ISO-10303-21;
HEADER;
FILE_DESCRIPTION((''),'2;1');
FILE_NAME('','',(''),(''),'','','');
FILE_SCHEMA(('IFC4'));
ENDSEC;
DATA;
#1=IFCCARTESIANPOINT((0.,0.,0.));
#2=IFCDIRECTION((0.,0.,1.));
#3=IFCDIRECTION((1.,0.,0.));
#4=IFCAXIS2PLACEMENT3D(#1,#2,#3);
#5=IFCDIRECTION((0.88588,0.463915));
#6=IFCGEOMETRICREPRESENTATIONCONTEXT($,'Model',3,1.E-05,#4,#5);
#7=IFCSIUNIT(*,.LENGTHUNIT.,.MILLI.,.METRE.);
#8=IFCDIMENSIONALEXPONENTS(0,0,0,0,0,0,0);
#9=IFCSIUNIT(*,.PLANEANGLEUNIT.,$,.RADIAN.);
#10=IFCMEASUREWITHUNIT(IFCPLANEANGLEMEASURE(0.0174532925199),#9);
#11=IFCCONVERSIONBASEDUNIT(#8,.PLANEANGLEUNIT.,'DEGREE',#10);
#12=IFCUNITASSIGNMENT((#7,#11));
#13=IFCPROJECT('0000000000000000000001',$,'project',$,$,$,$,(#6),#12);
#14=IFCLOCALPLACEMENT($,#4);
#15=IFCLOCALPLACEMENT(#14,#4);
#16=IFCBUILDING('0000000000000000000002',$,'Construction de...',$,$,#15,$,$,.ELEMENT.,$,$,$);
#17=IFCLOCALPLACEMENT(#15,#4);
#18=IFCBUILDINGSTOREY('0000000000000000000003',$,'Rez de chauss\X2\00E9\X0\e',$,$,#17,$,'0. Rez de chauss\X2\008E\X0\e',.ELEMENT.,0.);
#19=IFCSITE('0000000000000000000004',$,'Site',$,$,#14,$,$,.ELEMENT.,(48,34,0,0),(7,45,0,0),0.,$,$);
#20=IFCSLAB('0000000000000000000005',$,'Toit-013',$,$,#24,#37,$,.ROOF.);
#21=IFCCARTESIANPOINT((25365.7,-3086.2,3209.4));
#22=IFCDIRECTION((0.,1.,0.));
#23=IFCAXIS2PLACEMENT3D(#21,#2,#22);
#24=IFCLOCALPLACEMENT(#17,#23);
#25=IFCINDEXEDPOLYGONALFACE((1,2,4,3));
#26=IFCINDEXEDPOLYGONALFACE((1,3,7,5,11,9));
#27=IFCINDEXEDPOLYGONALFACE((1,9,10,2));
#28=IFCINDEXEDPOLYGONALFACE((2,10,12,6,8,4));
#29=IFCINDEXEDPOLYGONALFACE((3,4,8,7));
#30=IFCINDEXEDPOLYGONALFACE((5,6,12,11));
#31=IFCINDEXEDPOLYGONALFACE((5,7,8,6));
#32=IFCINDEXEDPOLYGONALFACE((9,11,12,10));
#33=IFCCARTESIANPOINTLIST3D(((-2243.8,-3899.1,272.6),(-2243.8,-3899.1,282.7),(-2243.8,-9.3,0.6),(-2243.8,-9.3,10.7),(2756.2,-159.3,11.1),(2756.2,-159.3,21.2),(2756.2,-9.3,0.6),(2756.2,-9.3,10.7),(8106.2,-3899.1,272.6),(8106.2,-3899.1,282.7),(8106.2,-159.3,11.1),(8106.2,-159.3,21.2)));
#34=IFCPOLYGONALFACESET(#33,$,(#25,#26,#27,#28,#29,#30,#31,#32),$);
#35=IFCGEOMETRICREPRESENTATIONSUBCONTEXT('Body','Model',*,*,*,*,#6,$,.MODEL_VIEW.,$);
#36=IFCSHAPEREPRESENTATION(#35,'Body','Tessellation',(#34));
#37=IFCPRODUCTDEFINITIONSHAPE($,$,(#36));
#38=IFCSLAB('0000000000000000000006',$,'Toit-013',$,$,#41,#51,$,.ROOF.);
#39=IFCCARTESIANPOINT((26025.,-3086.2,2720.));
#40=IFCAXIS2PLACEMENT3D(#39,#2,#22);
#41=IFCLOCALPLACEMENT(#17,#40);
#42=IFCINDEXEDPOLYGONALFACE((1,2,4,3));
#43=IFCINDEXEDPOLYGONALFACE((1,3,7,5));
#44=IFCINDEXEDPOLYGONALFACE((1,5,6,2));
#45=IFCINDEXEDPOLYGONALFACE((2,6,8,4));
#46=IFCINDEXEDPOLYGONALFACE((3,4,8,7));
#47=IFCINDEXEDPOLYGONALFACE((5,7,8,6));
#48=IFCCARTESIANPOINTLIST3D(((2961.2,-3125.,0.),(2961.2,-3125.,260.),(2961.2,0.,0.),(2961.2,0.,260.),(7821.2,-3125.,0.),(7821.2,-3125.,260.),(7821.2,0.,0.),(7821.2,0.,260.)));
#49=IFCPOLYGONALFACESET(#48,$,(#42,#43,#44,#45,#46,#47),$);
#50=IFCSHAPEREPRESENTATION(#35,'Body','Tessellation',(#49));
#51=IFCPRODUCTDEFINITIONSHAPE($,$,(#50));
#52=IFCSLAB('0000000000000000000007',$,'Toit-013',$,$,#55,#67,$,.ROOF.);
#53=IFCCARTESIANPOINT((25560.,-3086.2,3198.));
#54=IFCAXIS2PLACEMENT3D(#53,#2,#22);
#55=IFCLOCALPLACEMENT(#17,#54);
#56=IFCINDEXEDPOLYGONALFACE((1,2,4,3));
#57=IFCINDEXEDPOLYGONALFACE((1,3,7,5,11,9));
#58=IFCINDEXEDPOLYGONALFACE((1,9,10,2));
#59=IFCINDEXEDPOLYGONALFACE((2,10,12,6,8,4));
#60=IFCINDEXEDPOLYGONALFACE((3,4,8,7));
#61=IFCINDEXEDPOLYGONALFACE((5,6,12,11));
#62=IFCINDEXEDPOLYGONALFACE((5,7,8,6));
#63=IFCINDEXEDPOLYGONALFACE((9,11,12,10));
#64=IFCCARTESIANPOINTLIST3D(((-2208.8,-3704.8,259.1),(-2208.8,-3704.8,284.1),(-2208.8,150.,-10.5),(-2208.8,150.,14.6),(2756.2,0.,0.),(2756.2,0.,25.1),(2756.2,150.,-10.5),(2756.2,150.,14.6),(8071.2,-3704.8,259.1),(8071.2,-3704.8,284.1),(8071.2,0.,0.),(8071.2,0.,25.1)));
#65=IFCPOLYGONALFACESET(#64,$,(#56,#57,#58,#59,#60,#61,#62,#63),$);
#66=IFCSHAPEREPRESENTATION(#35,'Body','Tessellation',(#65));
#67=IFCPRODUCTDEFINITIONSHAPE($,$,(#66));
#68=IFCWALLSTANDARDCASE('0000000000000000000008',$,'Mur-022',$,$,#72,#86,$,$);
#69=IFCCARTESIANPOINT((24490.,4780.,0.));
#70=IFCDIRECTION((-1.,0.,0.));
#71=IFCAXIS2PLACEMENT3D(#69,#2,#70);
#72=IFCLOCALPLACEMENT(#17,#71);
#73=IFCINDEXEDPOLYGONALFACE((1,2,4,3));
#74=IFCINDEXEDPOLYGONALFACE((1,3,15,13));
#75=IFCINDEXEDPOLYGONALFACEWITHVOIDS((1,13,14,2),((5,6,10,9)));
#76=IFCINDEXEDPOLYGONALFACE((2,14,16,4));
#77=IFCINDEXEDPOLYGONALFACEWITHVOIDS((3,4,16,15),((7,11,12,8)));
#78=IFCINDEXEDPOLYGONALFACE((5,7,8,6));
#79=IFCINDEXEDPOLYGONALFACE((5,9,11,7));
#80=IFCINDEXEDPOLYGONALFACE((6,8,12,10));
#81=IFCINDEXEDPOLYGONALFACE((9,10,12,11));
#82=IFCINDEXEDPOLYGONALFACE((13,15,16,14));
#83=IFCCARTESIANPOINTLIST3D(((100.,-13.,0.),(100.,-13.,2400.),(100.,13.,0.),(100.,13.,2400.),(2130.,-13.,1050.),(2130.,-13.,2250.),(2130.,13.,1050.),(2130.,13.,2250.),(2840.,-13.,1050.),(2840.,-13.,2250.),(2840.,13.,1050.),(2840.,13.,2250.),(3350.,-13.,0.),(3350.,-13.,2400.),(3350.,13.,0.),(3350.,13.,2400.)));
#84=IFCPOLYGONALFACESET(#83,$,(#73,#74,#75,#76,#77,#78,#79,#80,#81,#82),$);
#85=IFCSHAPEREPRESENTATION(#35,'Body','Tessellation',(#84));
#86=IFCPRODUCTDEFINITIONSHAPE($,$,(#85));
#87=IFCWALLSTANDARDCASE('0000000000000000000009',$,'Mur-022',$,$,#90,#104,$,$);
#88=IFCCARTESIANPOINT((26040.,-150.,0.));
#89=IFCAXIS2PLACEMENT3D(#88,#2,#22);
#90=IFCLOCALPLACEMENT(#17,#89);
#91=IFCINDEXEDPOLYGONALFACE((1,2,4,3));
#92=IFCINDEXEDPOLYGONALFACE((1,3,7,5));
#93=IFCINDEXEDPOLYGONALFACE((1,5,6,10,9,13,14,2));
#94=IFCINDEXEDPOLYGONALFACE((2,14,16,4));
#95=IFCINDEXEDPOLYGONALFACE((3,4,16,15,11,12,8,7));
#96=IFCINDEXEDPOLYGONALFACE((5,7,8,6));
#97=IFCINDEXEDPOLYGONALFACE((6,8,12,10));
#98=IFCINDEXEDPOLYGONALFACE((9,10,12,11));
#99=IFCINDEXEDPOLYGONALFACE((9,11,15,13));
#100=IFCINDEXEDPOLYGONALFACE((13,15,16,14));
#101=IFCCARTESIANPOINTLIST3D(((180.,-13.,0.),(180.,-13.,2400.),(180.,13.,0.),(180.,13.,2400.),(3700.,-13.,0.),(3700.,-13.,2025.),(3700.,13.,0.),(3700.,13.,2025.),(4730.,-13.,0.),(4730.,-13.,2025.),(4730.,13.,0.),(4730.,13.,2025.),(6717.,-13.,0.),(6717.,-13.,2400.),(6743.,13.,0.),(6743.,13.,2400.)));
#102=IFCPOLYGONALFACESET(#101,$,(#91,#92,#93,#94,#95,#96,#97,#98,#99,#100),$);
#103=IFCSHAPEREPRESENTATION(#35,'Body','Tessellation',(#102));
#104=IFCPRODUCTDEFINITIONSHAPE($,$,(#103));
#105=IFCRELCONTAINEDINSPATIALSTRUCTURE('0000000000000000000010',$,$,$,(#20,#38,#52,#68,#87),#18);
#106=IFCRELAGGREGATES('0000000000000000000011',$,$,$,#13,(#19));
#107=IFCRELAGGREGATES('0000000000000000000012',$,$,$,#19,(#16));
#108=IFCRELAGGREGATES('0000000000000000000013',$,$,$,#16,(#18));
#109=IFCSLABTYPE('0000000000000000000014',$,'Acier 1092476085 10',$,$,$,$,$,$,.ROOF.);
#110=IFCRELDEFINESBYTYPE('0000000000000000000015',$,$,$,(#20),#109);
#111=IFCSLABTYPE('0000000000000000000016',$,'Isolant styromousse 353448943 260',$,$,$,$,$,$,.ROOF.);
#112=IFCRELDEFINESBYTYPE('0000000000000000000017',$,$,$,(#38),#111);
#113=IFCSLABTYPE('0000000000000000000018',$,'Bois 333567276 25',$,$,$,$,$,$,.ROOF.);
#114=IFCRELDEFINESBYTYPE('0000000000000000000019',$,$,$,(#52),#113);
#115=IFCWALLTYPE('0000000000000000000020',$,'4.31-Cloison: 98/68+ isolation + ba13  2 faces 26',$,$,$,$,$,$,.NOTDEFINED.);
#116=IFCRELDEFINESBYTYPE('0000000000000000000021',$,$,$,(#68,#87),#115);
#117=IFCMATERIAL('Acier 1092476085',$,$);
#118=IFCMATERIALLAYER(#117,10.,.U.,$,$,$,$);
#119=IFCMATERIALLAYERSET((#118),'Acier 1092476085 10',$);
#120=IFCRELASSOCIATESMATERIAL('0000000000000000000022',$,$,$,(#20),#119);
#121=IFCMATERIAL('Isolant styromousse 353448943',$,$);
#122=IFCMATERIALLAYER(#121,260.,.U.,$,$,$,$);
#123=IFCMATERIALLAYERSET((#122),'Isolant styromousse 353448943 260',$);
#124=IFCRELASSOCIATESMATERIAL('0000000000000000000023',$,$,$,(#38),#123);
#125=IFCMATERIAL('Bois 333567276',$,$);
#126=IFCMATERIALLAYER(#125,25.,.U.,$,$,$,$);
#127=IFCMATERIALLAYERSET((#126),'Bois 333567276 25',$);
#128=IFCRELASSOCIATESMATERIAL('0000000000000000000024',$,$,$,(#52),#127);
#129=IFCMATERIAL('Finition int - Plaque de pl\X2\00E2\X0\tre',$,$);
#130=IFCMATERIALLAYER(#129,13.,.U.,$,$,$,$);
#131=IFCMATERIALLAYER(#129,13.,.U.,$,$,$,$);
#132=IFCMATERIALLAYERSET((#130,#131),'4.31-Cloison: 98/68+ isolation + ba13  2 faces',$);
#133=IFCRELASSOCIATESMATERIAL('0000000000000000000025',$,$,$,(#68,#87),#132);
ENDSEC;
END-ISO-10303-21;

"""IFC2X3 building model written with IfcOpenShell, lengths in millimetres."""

from ifc_helpers import new_model, entity, si_unit, converted_unit, direction, frame, origin_with_axes, origin_2d_with_axis, place, context, subcontext, project, spatial, polyline, rectangle, outline, extrude, material, layer, layer_set, layer_usage, type_object, element, save


model = new_model("IFC2X3")

# Units and contexts
model_context = context("Model", 3, precision=1e-05, world=origin_with_axes(), true_north=direction((0.88588, 0.463915)))
body_context = subcontext(model_context, "Body", "Model", "MODEL_VIEW")
ifc_project = project(units=[si_unit("LENGTHUNIT", "METRE", prefix="MILLI"), converted_unit("PLANEANGLEUNIT", "DEGREE", entity("IfcPlaneAngleMeasure", 0.0174532925199), si_unit("PLANEANGLEUNIT", "RADIAN"), dimensions=[0, 0, 0, 0, 0, 0, 0])], contexts=[model_context])

# Site, building, storey
site_placement = place(None, origin_with_axes())
site = spatial("IfcSite", under=ifc_project, at=site_placement, Name="Site", CompositionType="ELEMENT", RefLatitude=(48, 34, 0, 0), RefLongitude=(7, 45, 0, 0), RefElevation=0.0)
building_placement = place(site_placement, origin_with_axes())
building = spatial("IfcBuilding", under=site, at=building_placement, Name="Construction de...", CompositionType="ELEMENT")
storey_placement = place(building_placement, origin_with_axes())
storey = spatial("IfcBuildingStorey", under=building, at=storey_placement, Name="Rez de chaussée", LongName="0. Rez de chauss\u008ee", CompositionType="ELEMENT", Elevation=0.0)

# Slabs
ifc_material_1 = material(Name="Acier 1092476085")
ifc_layer_1 = layer(ifc_material_1, 10.0, ventilated="UNKNOWN")
ifc_layer_set_1 = layer_set([ifc_layer_1], Name="Acier 1092476085 10")
ifc_layer_usage_1 = layer_usage(ifc_layer_set_1, "AXIS3", "NEGATIVE", 10.0)
slab_type_1 = type_object("IfcSlabType", Name="Acier 1092476085 10", PredefinedType="ROOF")
slab_1_placement = place(storey_placement, frame((25365.7, -3086.2, 3209.4), z_axis=(0.0, 0.0, 1.0), x_axis=(0.0, 1.0, 0.0)))
element("IfcSlab", 1, at=slab_1_placement, inside=storey, type_object=slab_type_1, material=ifc_layer_usage_1, Name="Toit-013", PredefinedType="ROOF", context=body_context, shape_type="SweptSolid", body=[
    extrude(outline(polyline([(-2243.8, -9.3), (-2243.8, -3908.6), (8106.2, -3908.6), (8106.2, -159.7), (2756.2, -159.7), (2756.2, -9.3), (-2243.8, -9.3)])), frame((0.0, 0.0, 0.0), z_axis=(0.0, 0.069756, 0.997564), x_axis=(1.0, 0.0, 0.0)), (0.0, -0.069756, 0.997564), 10.0),
])
ifc_material_2 = material(Name="Isolant styromousse 353448943")
ifc_layer_2 = layer(ifc_material_2, 260.0, ventilated="UNKNOWN")
ifc_layer_set_2 = layer_set([ifc_layer_2], Name="Isolant styromousse 353448943 260")
ifc_layer_usage_2 = layer_usage(ifc_layer_set_2, "AXIS3", "NEGATIVE", 260.0)
slab_type_2 = type_object("IfcSlabType", Name="Isolant styromousse 353448943 260", PredefinedType="ROOF")
slab_2_placement = place(storey_placement, frame((26025.0, -3086.2, 2720.0), z_axis=(0.0, 0.0, 1.0), x_axis=(0.0, 1.0, 0.0)))
element("IfcSlab", 2, at=slab_2_placement, inside=storey, type_object=slab_type_2, material=ifc_layer_usage_2, Name="Toit-013", PredefinedType="ROOF", context=body_context, shape_type="SweptSolid", body=[
    extrude(outline(polyline([(2961.2, 0.0), (2961.2, -3125.0), (7821.2, -3125.0), (7821.2, 0.0), (2961.2, 0.0)])), origin_with_axes(), (0.0, 0.0, 1.0), 260.0),
])
ifc_material_3 = material(Name="Bois 333567276")
ifc_layer_3 = layer(ifc_material_3, 25.0, ventilated="UNKNOWN")
ifc_layer_set_3 = layer_set([ifc_layer_3], Name="Bois 333567276 25")
ifc_layer_usage_3 = layer_usage(ifc_layer_set_3, "AXIS3", "NEGATIVE", 25.0)
slab_type_3 = type_object("IfcSlabType", Name="Bois 333567276 25", PredefinedType="ROOF")
slab_3_placement = place(storey_placement, frame((25560.0, -3086.2, 3198.0), z_axis=(0.0, 0.0, 1.0), x_axis=(0.0, 1.0, 0.0)))
element("IfcSlab", 3, at=slab_3_placement, inside=storey, type_object=slab_type_3, material=ifc_layer_usage_3, Name="Toit-013", PredefinedType="ROOF", context=body_context, shape_type="SweptSolid", body=[
    extrude(outline(polyline([(-2208.8, 150.4), (-2208.8, -3713.8), (8071.2, -3713.8), (8071.2, 0.0), (2756.2, 0.0), (2756.2, 150.4), (-2208.8, 150.4)])), frame((0.0, 0.0, 0.0), z_axis=(0.0, 0.069756, 0.997564), x_axis=(1.0, 0.0, 0.0)), (0.0, -0.069756, 0.997564), 25.1),
])

# Walls, openings
ifc_material_4 = material(Name="Finition int - Plaque de plâtre")
ifc_layer_4 = layer(ifc_material_4, 13.0, ventilated="UNKNOWN")
ifc_layer_5 = layer(ifc_material_4, 13.0, ventilated="UNKNOWN")
ifc_layer_set_4 = layer_set([ifc_layer_4, ifc_layer_5], Name="4.31-Cloison: 98/68+ isolation + ba13  2 faces")
ifc_layer_usage_4 = layer_usage(ifc_layer_set_4, "AXIS2", "NEGATIVE", 13.0)
wall_type_1 = type_object("IfcWallType", Name="4.31-Cloison: 98/68+ isolation + ba13  2 faces 26", PredefinedType="NOTDEFINED")
wall_1_placement = place(storey_placement, frame((24490.0, 4780.0, 0.0), z_axis=(0.0, 0.0, 1.0), x_axis=(-1.0, 0.0, 0.0)))
wall_1 = element("IfcWallStandardCase", 4, at=wall_1_placement, inside=storey, type_object=wall_type_1, material=ifc_layer_usage_4, Name="Mur-022", context=body_context, shape_type="SweptSolid", body=[
    extrude(outline(polyline([(100.0, -13.0), (3350.0, -13.0), (3350.0, 13.0), (100.0, 13.0), (100.0, -13.0)])), origin_with_axes(), (0.0, 0.0, 1.0), 2400.0),
])
opening_1_placement = place(wall_1_placement, frame((2485.0, 0.0, 1050.0), z_axis=(0.0, 0.0, 1.0), x_axis=(1.0, 0.0, 0.0)))
element("IfcOpeningElement", 5, at=opening_1_placement, cuts=wall_1, context=body_context, shape_type="SweptSolid", body=[
    extrude(rectangle(XDim=710.0, YDim=1200.0, at=origin_2d_with_axis()), frame((0.0, -13.0, 600.0), z_axis=(0.0, 1.0, 0.0), x_axis=(1.0, 0.0, 0.0)), (0.0, 0.0, -1.0), 26.0),
    extrude(rectangle(XDim=710.0, YDim=1200.0, at=origin_2d_with_axis()), frame((0.0, -13.0, 600.0), z_axis=(0.0, -1.0, 0.0), x_axis=(1.0, 0.0, 0.0)), (0.0, 0.0, -1.0), 26.0),
])
ifc_layer_usage_5 = layer_usage(ifc_layer_set_4, "AXIS2", "NEGATIVE", 13.0)
wall_2_placement = place(storey_placement, frame((26040.0, -150.0, 0.0), z_axis=(0.0, 0.0, 1.0), x_axis=(0.0, 1.0, 0.0)))
wall_2 = element("IfcWallStandardCase", 6, at=wall_2_placement, inside=storey, type_object=wall_type_1, material=ifc_layer_usage_5, Name="Mur-022", context=body_context, shape_type="SweptSolid", body=[
    extrude(outline(polyline([(180.0, -13.0), (6717.0, -13.0), (6743.0, 13.0), (180.0, 13.0), (180.0, -13.0)])), origin_with_axes(), (0.0, 0.0, 1.0), 2400.0),
])
opening_2_placement = place(wall_2_placement, frame((4215.0, 0.0, 0.0), z_axis=(0.0, 0.0, 1.0), x_axis=(1.0, 0.0, 0.0)))
element("IfcOpeningElement", 7, at=opening_2_placement, cuts=wall_2, context=body_context, shape_type="SweptSolid", body=[
    extrude(rectangle(XDim=1030.0, YDim=2025.0, at=origin_2d_with_axis()), frame((0.0, 26.0, 1012.5), z_axis=(0.0, 1.0, 0.0), x_axis=(1.0, 0.0, 0.0)), (0.0, 0.0, -1.0), 78.0),
])

save(model, "model.ifc")
